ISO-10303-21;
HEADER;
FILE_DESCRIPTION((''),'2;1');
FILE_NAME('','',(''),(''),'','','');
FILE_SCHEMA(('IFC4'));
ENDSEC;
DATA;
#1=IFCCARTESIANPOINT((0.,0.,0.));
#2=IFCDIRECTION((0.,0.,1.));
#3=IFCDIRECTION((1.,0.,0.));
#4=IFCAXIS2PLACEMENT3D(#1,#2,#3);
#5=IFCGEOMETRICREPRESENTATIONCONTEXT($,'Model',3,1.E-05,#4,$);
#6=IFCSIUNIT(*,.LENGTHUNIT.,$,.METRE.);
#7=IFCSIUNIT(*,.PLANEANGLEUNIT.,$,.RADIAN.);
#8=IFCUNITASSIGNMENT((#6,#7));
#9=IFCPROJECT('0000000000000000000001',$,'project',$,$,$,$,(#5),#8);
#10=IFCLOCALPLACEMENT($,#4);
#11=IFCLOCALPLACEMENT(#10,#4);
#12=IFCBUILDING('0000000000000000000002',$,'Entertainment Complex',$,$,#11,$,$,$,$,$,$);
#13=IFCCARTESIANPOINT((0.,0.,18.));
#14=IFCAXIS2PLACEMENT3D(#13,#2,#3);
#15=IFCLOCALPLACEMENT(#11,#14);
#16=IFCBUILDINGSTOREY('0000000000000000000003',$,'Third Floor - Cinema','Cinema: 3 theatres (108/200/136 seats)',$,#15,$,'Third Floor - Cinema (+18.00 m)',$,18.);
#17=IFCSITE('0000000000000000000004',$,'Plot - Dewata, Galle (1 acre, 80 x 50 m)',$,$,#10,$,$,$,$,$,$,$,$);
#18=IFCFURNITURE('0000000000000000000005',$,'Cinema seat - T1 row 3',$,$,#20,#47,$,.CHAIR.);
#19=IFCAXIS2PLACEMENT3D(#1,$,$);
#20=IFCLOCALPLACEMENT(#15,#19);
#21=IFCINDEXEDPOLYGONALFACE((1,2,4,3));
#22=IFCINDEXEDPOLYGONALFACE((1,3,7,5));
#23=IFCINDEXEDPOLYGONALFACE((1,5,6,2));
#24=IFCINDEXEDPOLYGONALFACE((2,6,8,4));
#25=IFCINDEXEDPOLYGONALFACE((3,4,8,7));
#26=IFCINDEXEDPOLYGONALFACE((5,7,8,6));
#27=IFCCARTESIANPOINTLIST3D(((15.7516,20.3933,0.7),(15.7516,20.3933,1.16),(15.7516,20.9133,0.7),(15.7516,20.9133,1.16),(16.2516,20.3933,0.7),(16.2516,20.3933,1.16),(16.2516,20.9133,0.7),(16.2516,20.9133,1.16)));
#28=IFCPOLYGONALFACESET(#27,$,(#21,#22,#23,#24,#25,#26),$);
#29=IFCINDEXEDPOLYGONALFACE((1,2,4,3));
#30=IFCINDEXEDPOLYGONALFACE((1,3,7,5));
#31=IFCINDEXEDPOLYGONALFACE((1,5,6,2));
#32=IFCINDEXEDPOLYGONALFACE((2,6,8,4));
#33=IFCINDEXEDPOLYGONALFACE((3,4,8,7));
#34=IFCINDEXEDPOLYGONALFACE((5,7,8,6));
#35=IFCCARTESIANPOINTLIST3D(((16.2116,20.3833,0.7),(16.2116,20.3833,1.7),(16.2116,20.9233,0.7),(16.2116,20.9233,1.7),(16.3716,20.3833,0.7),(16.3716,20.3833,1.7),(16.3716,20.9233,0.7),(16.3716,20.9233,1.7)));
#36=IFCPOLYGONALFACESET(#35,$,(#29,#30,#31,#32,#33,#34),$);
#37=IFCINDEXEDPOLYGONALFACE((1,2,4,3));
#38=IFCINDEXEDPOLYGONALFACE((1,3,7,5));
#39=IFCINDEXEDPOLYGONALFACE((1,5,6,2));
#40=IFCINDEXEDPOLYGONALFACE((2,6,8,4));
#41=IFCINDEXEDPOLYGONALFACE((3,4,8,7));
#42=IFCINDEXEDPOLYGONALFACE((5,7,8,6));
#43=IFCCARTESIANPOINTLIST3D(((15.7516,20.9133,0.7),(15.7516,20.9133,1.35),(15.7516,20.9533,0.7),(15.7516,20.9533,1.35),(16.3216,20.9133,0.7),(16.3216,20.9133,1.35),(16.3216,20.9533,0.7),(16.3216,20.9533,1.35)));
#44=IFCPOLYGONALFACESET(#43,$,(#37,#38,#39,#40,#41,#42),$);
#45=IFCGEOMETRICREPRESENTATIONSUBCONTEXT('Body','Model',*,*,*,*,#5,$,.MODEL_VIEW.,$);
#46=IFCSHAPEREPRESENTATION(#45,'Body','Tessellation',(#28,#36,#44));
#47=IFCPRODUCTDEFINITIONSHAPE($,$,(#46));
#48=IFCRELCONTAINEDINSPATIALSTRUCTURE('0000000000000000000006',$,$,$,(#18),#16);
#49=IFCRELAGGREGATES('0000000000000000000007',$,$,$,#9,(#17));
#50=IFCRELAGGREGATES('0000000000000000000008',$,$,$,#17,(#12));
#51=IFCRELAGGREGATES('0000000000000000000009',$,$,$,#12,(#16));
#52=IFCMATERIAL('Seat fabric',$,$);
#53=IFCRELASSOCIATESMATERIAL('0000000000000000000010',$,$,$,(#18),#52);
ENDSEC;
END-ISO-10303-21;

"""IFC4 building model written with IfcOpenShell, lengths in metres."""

from ifc_helpers import new_model, si_unit, frame, origin_with_axes, place, context, subcontext, project, spatial, polyline, outline, extrude, material, element, save


model = new_model("IFC4")

# Units and contexts
model_context = context("Model", 3, precision=1e-05, world=origin_with_axes())
body_context = subcontext(model_context, "Body", "Model", "MODEL_VIEW")
ifc_project = project(units=[si_unit("LENGTHUNIT", "METRE"), si_unit("PLANEANGLEUNIT", "RADIAN")], contexts=[model_context])

# Site, building, storey
site_placement = place(None, origin_with_axes())
site = spatial("IfcSite", under=ifc_project, at=site_placement, Name="Plot - Dewata, Galle (1 acre, 80 x 50 m)")
building_placement = place(site_placement, origin_with_axes())
building = spatial("IfcBuilding", under=site, at=building_placement, Name="Entertainment Complex")
storey_placement = place(building_placement, frame((0.0, 0.0, 18.0), z_axis=(0.0, 0.0, 1.0), x_axis=(1.0, 0.0, 0.0)))
storey = spatial("IfcBuildingStorey", under=building, at=storey_placement, Name="Third Floor - Cinema", Description="Cinema: 3 theatres (108/200/136 seats)", LongName="Third Floor - Cinema (+18.00 m)", Elevation=18.0)

# Furniture
ifc_material = material(Name="Seat fabric")
for number, where, z_axis, x_axis, name in (
    (1, (16.3716, 20.6533, 0.7), (0.0, 0.0, 1.0), (1.0, 0.0, 0.0), "Cinema seat - T1 row 3"),
):
    element("IfcFurniture", number, at=place(storey_placement, frame(where, z_axis=z_axis, x_axis=x_axis)), inside=storey, material=ifc_material, Name=name, PredefinedType="CHAIR", context=body_context, shape_type="SweptSolid", body=[
        extrude(outline(polyline([(-0.62, -0.26), (-0.12, -0.26), (-0.12, 0.26), (-0.62, 0.26), (-0.62, -0.26)])), origin_with_axes(), (0.0, 0.0, 1.0), 0.46),
        extrude(outline(polyline([(-0.16, -0.27), (0.0, -0.27), (0.0, 0.27), (-0.16, 0.27), (-0.16, -0.27)])), origin_with_axes(), (0.0, 0.0, 1.0), 1.0),
        extrude(outline(polyline([(-0.62, 0.26), (-0.05, 0.26), (-0.05, 0.3), (-0.62, 0.3), (-0.62, 0.26)])), origin_with_axes(), (0.0, 0.0, 1.0), 0.65),
    ])

save(model, "model.ifc")
